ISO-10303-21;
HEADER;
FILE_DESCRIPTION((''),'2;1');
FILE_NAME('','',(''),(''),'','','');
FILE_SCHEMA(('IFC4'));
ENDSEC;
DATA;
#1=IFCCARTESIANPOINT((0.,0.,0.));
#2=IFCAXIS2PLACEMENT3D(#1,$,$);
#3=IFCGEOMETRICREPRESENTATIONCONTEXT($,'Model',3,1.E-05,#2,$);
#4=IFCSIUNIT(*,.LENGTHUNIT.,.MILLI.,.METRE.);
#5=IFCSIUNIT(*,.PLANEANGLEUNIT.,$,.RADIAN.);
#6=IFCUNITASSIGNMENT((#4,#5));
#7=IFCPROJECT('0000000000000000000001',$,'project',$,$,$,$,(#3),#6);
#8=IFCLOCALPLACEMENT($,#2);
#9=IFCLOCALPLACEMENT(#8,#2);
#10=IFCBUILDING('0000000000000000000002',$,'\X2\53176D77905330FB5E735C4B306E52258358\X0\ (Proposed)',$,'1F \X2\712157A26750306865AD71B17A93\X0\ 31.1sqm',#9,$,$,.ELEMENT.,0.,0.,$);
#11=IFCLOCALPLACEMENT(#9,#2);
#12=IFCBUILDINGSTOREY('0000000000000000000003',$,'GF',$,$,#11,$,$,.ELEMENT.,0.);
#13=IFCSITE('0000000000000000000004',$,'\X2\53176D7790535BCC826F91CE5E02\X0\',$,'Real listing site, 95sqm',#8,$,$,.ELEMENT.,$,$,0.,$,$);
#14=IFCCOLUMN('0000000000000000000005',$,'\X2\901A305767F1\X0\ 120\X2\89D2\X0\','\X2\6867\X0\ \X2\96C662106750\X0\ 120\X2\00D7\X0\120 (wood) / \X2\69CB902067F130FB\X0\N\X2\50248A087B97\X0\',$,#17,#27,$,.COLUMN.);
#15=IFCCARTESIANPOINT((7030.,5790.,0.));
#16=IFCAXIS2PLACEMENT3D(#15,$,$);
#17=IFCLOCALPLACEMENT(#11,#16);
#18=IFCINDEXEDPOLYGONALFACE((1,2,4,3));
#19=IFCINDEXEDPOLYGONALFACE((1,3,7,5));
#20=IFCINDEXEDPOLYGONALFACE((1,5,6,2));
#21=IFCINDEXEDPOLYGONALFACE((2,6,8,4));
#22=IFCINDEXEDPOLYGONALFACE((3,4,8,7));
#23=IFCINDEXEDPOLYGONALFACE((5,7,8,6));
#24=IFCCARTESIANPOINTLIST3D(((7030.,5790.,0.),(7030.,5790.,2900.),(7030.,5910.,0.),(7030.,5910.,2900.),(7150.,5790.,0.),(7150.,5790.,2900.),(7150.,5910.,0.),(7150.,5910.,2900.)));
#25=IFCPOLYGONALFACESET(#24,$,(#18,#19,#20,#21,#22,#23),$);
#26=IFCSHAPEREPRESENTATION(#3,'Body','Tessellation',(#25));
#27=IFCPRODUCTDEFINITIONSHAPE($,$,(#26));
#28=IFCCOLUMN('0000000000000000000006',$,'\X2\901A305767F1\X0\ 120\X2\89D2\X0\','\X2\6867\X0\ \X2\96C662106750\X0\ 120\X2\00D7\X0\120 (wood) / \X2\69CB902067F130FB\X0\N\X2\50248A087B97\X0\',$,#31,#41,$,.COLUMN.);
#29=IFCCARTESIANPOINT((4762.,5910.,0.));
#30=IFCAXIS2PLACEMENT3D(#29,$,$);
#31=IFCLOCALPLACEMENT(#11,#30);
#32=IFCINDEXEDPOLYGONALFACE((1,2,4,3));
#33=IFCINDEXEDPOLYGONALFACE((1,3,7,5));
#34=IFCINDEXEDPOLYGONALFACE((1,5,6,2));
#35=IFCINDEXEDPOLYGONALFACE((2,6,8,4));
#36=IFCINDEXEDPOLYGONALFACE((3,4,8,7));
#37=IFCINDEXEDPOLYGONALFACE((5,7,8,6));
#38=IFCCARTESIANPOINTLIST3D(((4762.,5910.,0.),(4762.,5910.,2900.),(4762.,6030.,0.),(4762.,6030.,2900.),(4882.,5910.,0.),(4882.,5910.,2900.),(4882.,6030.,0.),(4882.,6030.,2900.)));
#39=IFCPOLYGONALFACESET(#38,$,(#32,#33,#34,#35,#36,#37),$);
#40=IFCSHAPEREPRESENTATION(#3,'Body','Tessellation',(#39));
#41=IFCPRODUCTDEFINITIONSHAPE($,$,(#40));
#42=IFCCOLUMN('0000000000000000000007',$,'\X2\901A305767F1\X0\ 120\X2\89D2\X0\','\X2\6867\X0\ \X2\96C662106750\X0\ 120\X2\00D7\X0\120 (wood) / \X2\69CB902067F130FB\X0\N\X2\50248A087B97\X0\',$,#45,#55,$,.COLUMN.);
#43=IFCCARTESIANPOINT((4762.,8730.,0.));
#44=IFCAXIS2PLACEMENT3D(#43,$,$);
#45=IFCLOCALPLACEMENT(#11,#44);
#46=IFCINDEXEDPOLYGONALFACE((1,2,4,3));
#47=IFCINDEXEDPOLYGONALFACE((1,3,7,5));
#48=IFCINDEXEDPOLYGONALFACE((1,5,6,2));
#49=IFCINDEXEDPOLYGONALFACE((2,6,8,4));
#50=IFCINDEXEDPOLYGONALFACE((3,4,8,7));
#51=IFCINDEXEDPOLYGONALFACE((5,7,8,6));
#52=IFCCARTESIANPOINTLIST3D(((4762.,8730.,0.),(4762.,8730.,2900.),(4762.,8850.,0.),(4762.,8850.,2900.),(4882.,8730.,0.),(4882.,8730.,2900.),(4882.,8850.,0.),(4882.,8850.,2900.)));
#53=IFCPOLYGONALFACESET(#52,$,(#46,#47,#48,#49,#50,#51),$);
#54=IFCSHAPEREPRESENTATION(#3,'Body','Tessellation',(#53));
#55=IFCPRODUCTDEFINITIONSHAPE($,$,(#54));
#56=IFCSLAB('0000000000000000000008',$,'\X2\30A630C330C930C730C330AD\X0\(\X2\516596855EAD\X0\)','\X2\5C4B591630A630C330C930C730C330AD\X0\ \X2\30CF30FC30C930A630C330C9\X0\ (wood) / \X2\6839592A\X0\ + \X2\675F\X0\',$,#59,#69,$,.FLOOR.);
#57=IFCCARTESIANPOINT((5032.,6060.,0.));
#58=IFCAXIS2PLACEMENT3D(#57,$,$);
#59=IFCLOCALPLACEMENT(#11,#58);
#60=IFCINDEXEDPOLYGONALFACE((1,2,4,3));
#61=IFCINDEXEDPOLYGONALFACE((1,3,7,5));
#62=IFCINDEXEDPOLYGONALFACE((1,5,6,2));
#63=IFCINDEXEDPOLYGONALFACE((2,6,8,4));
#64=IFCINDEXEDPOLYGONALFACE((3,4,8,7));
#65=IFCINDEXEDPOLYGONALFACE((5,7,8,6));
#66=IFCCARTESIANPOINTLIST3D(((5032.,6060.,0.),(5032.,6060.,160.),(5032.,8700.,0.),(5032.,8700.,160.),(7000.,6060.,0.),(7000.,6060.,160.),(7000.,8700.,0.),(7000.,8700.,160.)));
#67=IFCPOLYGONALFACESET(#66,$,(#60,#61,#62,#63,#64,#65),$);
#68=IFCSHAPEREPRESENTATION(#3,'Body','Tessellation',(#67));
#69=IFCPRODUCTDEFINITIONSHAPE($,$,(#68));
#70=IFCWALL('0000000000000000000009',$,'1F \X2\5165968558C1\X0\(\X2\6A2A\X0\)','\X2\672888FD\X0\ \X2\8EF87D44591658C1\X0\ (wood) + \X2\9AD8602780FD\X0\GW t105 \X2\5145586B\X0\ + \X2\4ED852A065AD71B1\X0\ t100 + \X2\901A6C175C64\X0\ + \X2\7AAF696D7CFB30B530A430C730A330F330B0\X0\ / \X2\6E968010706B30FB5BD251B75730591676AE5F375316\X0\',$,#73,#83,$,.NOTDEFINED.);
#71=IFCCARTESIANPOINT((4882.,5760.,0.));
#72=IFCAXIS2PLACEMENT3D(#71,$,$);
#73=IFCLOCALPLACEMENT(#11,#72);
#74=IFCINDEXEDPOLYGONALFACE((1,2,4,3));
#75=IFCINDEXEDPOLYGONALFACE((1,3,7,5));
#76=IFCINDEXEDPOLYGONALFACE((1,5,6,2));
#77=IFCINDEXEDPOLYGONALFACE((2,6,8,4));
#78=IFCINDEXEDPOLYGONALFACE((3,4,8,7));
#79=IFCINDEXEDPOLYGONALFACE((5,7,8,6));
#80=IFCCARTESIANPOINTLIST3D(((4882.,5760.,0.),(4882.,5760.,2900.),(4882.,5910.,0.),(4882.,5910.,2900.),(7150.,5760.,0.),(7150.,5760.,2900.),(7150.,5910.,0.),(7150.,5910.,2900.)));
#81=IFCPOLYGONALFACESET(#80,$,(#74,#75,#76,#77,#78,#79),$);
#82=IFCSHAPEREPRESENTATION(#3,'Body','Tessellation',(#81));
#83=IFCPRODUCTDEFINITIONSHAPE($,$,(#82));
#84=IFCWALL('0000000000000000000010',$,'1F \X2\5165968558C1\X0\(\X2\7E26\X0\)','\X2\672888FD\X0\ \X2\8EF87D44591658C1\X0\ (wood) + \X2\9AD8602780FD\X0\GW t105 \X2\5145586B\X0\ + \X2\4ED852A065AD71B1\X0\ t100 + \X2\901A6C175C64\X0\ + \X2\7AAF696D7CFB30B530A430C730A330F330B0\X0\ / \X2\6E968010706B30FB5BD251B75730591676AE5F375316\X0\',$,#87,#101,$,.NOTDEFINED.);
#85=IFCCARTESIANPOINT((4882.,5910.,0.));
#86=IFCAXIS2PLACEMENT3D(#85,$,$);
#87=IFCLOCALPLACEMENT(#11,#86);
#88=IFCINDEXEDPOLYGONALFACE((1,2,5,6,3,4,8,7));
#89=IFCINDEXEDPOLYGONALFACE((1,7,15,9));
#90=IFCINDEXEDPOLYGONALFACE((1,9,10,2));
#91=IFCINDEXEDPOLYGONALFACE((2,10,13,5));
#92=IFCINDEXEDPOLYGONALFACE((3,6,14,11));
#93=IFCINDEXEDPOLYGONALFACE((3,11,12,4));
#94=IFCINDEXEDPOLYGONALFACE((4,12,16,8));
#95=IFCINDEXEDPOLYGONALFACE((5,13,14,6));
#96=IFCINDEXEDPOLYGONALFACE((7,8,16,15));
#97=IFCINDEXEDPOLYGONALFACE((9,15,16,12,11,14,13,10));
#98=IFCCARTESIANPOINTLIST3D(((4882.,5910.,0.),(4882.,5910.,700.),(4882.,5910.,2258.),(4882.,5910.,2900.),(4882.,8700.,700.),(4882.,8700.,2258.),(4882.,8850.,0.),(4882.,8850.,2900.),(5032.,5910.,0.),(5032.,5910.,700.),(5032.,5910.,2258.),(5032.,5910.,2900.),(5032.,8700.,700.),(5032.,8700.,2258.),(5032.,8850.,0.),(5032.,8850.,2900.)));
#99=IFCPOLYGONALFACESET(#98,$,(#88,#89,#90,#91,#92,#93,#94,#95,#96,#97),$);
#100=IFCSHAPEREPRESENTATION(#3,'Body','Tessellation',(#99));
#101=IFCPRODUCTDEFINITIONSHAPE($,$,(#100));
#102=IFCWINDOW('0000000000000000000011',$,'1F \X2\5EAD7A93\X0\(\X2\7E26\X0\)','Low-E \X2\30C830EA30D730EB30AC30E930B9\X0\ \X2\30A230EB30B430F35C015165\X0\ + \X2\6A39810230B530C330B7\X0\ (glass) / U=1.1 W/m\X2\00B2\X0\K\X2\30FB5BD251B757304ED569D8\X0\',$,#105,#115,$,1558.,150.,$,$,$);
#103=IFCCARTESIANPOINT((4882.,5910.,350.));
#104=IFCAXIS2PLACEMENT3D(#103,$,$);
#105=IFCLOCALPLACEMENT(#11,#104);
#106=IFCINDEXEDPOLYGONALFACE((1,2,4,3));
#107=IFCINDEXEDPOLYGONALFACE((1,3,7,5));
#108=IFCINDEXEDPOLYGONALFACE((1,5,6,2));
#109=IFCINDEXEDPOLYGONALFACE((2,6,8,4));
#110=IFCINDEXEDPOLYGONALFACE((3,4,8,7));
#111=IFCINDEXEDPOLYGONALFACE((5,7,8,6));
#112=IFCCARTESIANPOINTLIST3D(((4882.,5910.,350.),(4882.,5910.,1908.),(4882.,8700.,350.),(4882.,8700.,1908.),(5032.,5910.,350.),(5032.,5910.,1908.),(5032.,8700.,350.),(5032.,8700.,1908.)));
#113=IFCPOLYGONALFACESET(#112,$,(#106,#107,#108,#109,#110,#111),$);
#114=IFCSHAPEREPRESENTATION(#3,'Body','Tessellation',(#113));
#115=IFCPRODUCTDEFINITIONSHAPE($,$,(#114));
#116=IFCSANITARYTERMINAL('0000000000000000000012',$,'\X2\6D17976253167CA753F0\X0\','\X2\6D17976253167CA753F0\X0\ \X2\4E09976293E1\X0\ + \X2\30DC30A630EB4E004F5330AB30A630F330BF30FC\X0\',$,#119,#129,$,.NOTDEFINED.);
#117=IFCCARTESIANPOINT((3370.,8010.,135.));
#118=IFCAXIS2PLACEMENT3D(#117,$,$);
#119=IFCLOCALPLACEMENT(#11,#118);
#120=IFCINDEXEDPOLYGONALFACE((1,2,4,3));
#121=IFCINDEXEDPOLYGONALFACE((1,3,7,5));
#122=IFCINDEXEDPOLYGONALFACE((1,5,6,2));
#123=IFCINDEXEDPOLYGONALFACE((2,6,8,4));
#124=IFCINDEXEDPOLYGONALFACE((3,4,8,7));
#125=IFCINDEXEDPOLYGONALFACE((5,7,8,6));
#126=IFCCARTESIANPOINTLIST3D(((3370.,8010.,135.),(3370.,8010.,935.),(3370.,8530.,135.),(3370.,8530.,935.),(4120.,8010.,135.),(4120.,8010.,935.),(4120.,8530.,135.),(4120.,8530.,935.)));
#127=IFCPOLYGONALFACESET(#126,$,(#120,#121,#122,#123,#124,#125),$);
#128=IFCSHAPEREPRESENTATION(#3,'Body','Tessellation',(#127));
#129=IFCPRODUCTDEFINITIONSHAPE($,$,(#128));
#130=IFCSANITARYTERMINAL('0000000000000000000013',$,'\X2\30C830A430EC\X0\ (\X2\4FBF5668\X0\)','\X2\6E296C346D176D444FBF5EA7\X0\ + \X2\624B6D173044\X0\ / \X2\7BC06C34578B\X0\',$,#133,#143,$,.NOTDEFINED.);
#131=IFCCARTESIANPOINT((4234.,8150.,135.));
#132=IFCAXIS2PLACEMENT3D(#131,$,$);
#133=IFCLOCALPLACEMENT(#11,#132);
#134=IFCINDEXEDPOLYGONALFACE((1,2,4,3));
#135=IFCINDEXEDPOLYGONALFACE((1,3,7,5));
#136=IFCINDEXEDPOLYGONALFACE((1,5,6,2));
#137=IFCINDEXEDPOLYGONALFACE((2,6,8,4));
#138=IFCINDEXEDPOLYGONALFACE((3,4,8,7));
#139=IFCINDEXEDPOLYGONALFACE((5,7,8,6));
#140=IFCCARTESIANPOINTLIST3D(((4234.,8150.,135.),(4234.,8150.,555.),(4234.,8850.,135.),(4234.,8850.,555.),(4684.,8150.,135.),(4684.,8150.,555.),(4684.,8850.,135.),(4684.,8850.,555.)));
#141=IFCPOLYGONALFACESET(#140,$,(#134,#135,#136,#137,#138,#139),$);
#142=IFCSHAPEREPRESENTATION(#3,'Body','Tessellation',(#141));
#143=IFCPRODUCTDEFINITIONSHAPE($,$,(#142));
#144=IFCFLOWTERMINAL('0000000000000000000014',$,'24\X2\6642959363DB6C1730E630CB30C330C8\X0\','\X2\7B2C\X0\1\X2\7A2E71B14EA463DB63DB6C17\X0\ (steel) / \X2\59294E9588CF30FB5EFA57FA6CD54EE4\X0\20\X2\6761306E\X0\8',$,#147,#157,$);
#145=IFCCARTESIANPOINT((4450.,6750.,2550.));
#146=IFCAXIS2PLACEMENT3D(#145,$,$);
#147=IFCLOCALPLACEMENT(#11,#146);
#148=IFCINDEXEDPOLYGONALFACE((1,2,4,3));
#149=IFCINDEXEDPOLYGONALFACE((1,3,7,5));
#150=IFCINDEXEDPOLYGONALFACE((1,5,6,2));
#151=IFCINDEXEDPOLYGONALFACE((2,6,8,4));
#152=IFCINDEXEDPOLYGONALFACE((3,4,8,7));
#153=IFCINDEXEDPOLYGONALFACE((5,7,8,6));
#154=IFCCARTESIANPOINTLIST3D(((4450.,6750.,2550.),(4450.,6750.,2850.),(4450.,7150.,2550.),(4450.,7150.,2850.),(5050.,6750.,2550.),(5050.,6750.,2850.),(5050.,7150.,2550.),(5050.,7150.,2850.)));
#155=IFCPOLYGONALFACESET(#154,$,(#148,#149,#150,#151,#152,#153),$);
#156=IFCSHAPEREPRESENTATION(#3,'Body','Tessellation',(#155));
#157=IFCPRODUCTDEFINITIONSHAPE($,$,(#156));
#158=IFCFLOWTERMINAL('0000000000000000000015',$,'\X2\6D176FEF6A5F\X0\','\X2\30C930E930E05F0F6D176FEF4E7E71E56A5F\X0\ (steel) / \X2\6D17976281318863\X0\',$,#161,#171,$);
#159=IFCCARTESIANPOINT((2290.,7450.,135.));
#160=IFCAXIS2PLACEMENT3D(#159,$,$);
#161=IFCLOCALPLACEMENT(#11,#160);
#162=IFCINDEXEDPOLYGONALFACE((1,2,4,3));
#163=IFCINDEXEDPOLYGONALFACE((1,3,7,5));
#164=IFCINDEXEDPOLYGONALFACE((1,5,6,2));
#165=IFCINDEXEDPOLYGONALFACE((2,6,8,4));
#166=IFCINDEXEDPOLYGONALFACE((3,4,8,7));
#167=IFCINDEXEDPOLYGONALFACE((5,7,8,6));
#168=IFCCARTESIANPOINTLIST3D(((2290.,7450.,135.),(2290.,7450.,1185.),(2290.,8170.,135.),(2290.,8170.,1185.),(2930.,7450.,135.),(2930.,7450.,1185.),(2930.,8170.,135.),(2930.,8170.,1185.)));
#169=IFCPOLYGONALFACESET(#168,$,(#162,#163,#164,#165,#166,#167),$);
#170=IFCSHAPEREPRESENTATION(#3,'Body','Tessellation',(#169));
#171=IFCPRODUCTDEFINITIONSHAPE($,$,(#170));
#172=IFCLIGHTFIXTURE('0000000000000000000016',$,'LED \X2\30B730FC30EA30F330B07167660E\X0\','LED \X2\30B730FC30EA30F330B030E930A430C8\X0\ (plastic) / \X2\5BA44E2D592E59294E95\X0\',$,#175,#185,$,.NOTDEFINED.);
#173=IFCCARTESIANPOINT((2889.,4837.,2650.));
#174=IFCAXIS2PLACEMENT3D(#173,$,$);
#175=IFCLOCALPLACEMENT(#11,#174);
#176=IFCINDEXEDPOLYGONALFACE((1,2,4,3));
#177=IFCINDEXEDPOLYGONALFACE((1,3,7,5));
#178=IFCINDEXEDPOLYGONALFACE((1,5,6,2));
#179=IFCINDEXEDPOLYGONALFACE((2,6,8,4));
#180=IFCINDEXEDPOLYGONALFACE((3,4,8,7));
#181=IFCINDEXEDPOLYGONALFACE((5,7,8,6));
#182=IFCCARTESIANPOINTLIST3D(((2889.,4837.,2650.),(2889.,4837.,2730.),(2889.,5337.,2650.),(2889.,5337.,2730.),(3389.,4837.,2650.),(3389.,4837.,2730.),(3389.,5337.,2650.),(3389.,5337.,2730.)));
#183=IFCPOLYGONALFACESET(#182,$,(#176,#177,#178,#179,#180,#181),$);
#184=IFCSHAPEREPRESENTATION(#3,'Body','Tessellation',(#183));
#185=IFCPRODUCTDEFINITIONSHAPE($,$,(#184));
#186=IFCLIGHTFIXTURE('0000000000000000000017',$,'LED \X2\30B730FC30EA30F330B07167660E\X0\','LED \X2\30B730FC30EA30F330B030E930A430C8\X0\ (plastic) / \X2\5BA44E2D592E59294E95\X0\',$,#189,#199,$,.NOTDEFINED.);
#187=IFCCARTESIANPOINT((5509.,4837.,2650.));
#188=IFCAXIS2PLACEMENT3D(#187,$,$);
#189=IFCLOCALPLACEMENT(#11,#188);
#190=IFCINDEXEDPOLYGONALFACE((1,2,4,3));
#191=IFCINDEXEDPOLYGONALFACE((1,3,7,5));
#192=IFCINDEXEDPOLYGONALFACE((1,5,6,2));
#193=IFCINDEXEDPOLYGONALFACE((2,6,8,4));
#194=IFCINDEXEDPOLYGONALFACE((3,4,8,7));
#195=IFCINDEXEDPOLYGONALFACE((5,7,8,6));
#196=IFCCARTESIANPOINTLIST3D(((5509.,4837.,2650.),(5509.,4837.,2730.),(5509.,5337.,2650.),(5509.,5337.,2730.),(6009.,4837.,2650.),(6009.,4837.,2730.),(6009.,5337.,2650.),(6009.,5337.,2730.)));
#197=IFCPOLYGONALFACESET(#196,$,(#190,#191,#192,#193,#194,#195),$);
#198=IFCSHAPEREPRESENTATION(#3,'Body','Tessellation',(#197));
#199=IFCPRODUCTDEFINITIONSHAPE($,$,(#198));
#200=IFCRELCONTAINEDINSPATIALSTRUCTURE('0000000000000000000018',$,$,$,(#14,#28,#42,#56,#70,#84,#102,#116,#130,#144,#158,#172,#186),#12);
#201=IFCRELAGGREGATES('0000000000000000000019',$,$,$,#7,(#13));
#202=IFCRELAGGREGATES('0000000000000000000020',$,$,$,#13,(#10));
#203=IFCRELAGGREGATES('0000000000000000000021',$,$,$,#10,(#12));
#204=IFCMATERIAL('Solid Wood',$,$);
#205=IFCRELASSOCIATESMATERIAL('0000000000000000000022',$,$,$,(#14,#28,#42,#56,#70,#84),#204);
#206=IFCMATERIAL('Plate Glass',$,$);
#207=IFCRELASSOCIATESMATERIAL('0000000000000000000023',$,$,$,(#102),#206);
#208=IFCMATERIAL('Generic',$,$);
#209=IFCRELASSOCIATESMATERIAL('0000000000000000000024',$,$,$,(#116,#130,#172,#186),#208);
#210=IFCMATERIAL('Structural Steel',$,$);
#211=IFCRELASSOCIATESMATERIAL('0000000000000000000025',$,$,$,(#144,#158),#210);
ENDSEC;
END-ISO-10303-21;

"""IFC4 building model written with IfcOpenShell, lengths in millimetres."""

from ifc_helpers import new_model, si_unit, frame, frame_2d, origin, place, context, project, spatial, rectangle, extrude, material, element, fill, save


model = new_model("IFC4")

# Units and contexts
model_context = context("Model", 3, precision=1e-05, world=origin())
ifc_project = project(units=[si_unit("LENGTHUNIT", "METRE", prefix="MILLI"), si_unit("PLANEANGLEUNIT", "RADIAN")], contexts=[model_context])

# Site, building, storey
site_placement = place(None, origin())
site = spatial("IfcSite", under=ifc_project, at=site_placement, Name="北海道富良野市", ObjectType="Real listing site, 95sqm", CompositionType="ELEMENT", RefElevation=0.0)
building_placement = place(site_placement, origin())
building = spatial("IfcBuilding", under=site, at=building_placement, Name="北海道・平屋の別荘 (Proposed)", ObjectType="1F 無垢材と断熱窓 31.1sqm", CompositionType="ELEMENT", ElevationOfRefHeight=0.0, ElevationOfTerrain=0.0)
storey_placement = place(building_placement, origin())
storey = spatial("IfcBuildingStorey", under=building, at=storey_placement, Name="GF", CompositionType="ELEMENT", Elevation=0.0)

# Columns
ifc_material_1 = material(Name="Solid Wood")
column_1_placement = place(storey_placement, frame((7030.0, 5790.0, 0.0)))
element("IfcColumn", 1, at=column_1_placement, inside=storey, material=ifc_material_1, Name="通し柱 120角", Description="桧 集成材 120×120 (wood) / 構造柱・N値計算", PredefinedType="COLUMN", context=model_context, shape_type="SweptSolid", body=[
    extrude(rectangle(XDim=120.0, YDim=120.0, at=frame_2d((60.0, 60.0))), frame((7030.0, 5790.0, 0.0)), (0.0, 0.0, 1.0), 2900.0),
])
column_2_placement = place(storey_placement, frame((4762.0, 5910.0, 0.0)))
element("IfcColumn", 2, at=column_2_placement, inside=storey, material=ifc_material_1, Name="通し柱 120角", Description="桧 集成材 120×120 (wood) / 構造柱・N値計算", PredefinedType="COLUMN", context=model_context, shape_type="SweptSolid", body=[
    extrude(rectangle(XDim=120.0, YDim=120.0, at=frame_2d((60.0, 60.0))), frame((4762.0, 5910.0, 0.0)), (0.0, 0.0, 1.0), 2900.0),
])
column_3_placement = place(storey_placement, frame((4762.0, 8730.0, 0.0)))
element("IfcColumn", 3, at=column_3_placement, inside=storey, material=ifc_material_1, Name="通し柱 120角", Description="桧 集成材 120×120 (wood) / 構造柱・N値計算", PredefinedType="COLUMN", context=model_context, shape_type="SweptSolid", body=[
    extrude(rectangle(XDim=120.0, YDim=120.0, at=frame_2d((60.0, 60.0))), frame((4762.0, 8730.0, 0.0)), (0.0, 0.0, 1.0), 2900.0),
])

# Slab
slab_placement = place(storey_placement, frame((5032.0, 6060.0, 0.0)))
element("IfcSlab", 4, at=slab_placement, inside=storey, material=ifc_material_1, Name="ウッドデッキ(入隅庭)", Description="屋外ウッドデッキ ハードウッド (wood) / 根太 + 束", PredefinedType="FLOOR", context=model_context, shape_type="SweptSolid", body=[
    extrude(rectangle(XDim=1968.0, YDim=2640.0, at=frame_2d((984.0, 1320.0))), frame((5032.0, 6060.0, 0.0)), (0.0, 0.0, 1.0), 160.0),
])

# Wall
wall_1_placement = place(storey_placement, frame((4882.0, 5760.0, 0.0)))
element("IfcWall", 5, at=wall_1_placement, inside=storey, material=ifc_material_1, Name="1F 入隅壁(横)", Description="木製 軸組外壁 (wood) + 高性能GW t105 充填 + 付加断熱 t100 + 通気層 + 窯業系サイディング / 準耐火・寒冷地外皮強化", PredefinedType="NOTDEFINED", context=model_context, shape_type="SweptSolid", body=[
    extrude(rectangle(XDim=2268.0, YDim=150.0, at=frame_2d((1134.0, 75.0))), frame((4882.0, 5760.0, 0.0)), (0.0, 0.0, 1.0), 2900.0),
])

# Wall, opening, window
wall_2_placement = place(storey_placement, frame((4882.0, 5910.0, 0.0)))
wall_2 = element("IfcWall", 6, at=wall_2_placement, inside=storey, material=ifc_material_1, Name="1F 入隅壁(縦)", Description="木製 軸組外壁 (wood) + 高性能GW t105 充填 + 付加断熱 t100 + 通気層 + 窯業系サイディング / 準耐火・寒冷地外皮強化", PredefinedType="NOTDEFINED", context=model_context, shape_type="SweptSolid", body=[
    extrude(rectangle(XDim=150.0, YDim=2940.0, at=frame_2d((75.0, 1470.0))), frame((4882.0, 5910.0, 0.0)), (0.0, 0.0, 1.0), 2900.0),
])
opening_placement = place(storey_placement, frame((4882.0, 5910.0, 350.0)))
opening = element("IfcOpeningElement", 7, at=opening_placement, cuts=wall_2, PredefinedType="NOTDEFINED", context=model_context, shape_type="SweptSolid", body=[
    extrude(rectangle(XDim=150.0, YDim=2790.0, at=frame_2d((75.0, 1395.0))), frame((4882.0, 5910.0, 350.0)), (0.0, 0.0, 1.0), 1558.0),
])
ifc_material_2 = material(Name="Plate Glass")
window_placement = place(storey_placement, frame((4882.0, 5910.0, 350.0)))
window = element("IfcWindow", 8, at=window_placement, inside=storey, material=ifc_material_2, Name="1F 庭窓(縦)", Description="Low-E トリプルガラス アルゴン封入 + 樹脂サッシ (glass) / U=1.1 W/m²K・寒冷地仕様", OverallHeight=1558.0, OverallWidth=150.0, context=model_context, shape_type="SweptSolid", body=[
    extrude(rectangle(XDim=150.0, YDim=2790.0, at=frame_2d((75.0, 1395.0))), frame((4882.0, 5910.0, 350.0)), (0.0, 0.0, 1.0), 1558.0),
])
fill(opening, window)

# Sanitary terminals
ifc_material_3 = material(Name="Generic")
sanitary_terminal_1_placement = place(storey_placement, frame((3370.0, 8010.0, 135.0)))
element("IfcSanitaryTerminal", 9, at=sanitary_terminal_1_placement, inside=storey, material=ifc_material_3, Name="洗面化粧台", Description="洗面化粧台 三面鏡 + ボウル一体カウンター", PredefinedType="NOTDEFINED", context=model_context, shape_type="SweptSolid", body=[
    extrude(rectangle(XDim=750.0, YDim=520.0, at=frame_2d((375.0, 260.0))), frame((3370.0, 8010.0, 135.0)), (0.0, 0.0, 1.0), 800.0),
])
sanitary_terminal_2_placement = place(storey_placement, frame((4234.0, 8150.0, 135.0)))
element("IfcSanitaryTerminal", 10, at=sanitary_terminal_2_placement, inside=storey, material=ifc_material_3, Name="トイレ (便器)", Description="温水洗浄便座 + 手洗い / 節水型", PredefinedType="NOTDEFINED", context=model_context, shape_type="SweptSolid", body=[
    extrude(rectangle(XDim=450.0, YDim=700.0, at=frame_2d((225.0, 350.0))), frame((4234.0, 8150.0, 135.0)), (0.0, 0.0, 1.0), 420.0),
])

# Flow terminals
ifc_material_4 = material(Name="Structural Steel")
flow_terminal_1_placement = place(storey_placement, frame((4450.0, 6750.0, 2550.0)))
element("IfcFlowTerminal", 11, at=flow_terminal_1_placement, inside=storey, material=ifc_material_4, Name="24時間換気ユニット", Description="第1種熱交換換気 (steel) / 天井裏・建基法令20条の8", context=model_context, shape_type="SweptSolid", body=[
    extrude(rectangle(XDim=600.0, YDim=400.0, at=frame_2d((300.0, 200.0))), frame((4450.0, 6750.0, 2550.0)), (0.0, 0.0, 1.0), 300.0),
])
flow_terminal_2_placement = place(storey_placement, frame((2290.0, 7450.0, 135.0)))
element("IfcFlowTerminal", 12, at=flow_terminal_2_placement, inside=storey, material=ifc_material_4, Name="洗濯機", Description="ドラム式洗濯乾燥機 (steel) / 洗面脱衣", context=model_context, shape_type="SweptSolid", body=[
    extrude(rectangle(XDim=640.0, YDim=720.0, at=frame_2d((320.0, 360.0))), frame((2290.0, 7450.0, 135.0)), (0.0, 0.0, 1.0), 1050.0),
])

# Light fixtures
light_fixture_1_placement = place(storey_placement, frame((2889.0, 4837.0, 2650.0)))
element("IfcLightFixture", 13, at=light_fixture_1_placement, inside=storey, material=ifc_material_3, Name="LED シーリング照明", Description="LED シーリングライト (plastic) / 室中央天井", PredefinedType="NOTDEFINED", context=model_context, shape_type="SweptSolid", body=[
    extrude(rectangle(XDim=500.0, YDim=500.0, at=frame_2d((250.0, 250.0))), frame((2889.0, 4837.0, 2650.0)), (0.0, 0.0, 1.0), 80.0),
])
light_fixture_2_placement = place(storey_placement, frame((5509.0, 4837.0, 2650.0)))
element("IfcLightFixture", 14, at=light_fixture_2_placement, inside=storey, material=ifc_material_3, Name="LED シーリング照明", Description="LED シーリングライト (plastic) / 室中央天井", PredefinedType="NOTDEFINED", context=model_context, shape_type="SweptSolid", body=[
    extrude(rectangle(XDim=500.0, YDim=500.0, at=frame_2d((250.0, 250.0))), frame((5509.0, 4837.0, 2650.0)), (0.0, 0.0, 1.0), 80.0),
])

save(model, "model.ifc")
